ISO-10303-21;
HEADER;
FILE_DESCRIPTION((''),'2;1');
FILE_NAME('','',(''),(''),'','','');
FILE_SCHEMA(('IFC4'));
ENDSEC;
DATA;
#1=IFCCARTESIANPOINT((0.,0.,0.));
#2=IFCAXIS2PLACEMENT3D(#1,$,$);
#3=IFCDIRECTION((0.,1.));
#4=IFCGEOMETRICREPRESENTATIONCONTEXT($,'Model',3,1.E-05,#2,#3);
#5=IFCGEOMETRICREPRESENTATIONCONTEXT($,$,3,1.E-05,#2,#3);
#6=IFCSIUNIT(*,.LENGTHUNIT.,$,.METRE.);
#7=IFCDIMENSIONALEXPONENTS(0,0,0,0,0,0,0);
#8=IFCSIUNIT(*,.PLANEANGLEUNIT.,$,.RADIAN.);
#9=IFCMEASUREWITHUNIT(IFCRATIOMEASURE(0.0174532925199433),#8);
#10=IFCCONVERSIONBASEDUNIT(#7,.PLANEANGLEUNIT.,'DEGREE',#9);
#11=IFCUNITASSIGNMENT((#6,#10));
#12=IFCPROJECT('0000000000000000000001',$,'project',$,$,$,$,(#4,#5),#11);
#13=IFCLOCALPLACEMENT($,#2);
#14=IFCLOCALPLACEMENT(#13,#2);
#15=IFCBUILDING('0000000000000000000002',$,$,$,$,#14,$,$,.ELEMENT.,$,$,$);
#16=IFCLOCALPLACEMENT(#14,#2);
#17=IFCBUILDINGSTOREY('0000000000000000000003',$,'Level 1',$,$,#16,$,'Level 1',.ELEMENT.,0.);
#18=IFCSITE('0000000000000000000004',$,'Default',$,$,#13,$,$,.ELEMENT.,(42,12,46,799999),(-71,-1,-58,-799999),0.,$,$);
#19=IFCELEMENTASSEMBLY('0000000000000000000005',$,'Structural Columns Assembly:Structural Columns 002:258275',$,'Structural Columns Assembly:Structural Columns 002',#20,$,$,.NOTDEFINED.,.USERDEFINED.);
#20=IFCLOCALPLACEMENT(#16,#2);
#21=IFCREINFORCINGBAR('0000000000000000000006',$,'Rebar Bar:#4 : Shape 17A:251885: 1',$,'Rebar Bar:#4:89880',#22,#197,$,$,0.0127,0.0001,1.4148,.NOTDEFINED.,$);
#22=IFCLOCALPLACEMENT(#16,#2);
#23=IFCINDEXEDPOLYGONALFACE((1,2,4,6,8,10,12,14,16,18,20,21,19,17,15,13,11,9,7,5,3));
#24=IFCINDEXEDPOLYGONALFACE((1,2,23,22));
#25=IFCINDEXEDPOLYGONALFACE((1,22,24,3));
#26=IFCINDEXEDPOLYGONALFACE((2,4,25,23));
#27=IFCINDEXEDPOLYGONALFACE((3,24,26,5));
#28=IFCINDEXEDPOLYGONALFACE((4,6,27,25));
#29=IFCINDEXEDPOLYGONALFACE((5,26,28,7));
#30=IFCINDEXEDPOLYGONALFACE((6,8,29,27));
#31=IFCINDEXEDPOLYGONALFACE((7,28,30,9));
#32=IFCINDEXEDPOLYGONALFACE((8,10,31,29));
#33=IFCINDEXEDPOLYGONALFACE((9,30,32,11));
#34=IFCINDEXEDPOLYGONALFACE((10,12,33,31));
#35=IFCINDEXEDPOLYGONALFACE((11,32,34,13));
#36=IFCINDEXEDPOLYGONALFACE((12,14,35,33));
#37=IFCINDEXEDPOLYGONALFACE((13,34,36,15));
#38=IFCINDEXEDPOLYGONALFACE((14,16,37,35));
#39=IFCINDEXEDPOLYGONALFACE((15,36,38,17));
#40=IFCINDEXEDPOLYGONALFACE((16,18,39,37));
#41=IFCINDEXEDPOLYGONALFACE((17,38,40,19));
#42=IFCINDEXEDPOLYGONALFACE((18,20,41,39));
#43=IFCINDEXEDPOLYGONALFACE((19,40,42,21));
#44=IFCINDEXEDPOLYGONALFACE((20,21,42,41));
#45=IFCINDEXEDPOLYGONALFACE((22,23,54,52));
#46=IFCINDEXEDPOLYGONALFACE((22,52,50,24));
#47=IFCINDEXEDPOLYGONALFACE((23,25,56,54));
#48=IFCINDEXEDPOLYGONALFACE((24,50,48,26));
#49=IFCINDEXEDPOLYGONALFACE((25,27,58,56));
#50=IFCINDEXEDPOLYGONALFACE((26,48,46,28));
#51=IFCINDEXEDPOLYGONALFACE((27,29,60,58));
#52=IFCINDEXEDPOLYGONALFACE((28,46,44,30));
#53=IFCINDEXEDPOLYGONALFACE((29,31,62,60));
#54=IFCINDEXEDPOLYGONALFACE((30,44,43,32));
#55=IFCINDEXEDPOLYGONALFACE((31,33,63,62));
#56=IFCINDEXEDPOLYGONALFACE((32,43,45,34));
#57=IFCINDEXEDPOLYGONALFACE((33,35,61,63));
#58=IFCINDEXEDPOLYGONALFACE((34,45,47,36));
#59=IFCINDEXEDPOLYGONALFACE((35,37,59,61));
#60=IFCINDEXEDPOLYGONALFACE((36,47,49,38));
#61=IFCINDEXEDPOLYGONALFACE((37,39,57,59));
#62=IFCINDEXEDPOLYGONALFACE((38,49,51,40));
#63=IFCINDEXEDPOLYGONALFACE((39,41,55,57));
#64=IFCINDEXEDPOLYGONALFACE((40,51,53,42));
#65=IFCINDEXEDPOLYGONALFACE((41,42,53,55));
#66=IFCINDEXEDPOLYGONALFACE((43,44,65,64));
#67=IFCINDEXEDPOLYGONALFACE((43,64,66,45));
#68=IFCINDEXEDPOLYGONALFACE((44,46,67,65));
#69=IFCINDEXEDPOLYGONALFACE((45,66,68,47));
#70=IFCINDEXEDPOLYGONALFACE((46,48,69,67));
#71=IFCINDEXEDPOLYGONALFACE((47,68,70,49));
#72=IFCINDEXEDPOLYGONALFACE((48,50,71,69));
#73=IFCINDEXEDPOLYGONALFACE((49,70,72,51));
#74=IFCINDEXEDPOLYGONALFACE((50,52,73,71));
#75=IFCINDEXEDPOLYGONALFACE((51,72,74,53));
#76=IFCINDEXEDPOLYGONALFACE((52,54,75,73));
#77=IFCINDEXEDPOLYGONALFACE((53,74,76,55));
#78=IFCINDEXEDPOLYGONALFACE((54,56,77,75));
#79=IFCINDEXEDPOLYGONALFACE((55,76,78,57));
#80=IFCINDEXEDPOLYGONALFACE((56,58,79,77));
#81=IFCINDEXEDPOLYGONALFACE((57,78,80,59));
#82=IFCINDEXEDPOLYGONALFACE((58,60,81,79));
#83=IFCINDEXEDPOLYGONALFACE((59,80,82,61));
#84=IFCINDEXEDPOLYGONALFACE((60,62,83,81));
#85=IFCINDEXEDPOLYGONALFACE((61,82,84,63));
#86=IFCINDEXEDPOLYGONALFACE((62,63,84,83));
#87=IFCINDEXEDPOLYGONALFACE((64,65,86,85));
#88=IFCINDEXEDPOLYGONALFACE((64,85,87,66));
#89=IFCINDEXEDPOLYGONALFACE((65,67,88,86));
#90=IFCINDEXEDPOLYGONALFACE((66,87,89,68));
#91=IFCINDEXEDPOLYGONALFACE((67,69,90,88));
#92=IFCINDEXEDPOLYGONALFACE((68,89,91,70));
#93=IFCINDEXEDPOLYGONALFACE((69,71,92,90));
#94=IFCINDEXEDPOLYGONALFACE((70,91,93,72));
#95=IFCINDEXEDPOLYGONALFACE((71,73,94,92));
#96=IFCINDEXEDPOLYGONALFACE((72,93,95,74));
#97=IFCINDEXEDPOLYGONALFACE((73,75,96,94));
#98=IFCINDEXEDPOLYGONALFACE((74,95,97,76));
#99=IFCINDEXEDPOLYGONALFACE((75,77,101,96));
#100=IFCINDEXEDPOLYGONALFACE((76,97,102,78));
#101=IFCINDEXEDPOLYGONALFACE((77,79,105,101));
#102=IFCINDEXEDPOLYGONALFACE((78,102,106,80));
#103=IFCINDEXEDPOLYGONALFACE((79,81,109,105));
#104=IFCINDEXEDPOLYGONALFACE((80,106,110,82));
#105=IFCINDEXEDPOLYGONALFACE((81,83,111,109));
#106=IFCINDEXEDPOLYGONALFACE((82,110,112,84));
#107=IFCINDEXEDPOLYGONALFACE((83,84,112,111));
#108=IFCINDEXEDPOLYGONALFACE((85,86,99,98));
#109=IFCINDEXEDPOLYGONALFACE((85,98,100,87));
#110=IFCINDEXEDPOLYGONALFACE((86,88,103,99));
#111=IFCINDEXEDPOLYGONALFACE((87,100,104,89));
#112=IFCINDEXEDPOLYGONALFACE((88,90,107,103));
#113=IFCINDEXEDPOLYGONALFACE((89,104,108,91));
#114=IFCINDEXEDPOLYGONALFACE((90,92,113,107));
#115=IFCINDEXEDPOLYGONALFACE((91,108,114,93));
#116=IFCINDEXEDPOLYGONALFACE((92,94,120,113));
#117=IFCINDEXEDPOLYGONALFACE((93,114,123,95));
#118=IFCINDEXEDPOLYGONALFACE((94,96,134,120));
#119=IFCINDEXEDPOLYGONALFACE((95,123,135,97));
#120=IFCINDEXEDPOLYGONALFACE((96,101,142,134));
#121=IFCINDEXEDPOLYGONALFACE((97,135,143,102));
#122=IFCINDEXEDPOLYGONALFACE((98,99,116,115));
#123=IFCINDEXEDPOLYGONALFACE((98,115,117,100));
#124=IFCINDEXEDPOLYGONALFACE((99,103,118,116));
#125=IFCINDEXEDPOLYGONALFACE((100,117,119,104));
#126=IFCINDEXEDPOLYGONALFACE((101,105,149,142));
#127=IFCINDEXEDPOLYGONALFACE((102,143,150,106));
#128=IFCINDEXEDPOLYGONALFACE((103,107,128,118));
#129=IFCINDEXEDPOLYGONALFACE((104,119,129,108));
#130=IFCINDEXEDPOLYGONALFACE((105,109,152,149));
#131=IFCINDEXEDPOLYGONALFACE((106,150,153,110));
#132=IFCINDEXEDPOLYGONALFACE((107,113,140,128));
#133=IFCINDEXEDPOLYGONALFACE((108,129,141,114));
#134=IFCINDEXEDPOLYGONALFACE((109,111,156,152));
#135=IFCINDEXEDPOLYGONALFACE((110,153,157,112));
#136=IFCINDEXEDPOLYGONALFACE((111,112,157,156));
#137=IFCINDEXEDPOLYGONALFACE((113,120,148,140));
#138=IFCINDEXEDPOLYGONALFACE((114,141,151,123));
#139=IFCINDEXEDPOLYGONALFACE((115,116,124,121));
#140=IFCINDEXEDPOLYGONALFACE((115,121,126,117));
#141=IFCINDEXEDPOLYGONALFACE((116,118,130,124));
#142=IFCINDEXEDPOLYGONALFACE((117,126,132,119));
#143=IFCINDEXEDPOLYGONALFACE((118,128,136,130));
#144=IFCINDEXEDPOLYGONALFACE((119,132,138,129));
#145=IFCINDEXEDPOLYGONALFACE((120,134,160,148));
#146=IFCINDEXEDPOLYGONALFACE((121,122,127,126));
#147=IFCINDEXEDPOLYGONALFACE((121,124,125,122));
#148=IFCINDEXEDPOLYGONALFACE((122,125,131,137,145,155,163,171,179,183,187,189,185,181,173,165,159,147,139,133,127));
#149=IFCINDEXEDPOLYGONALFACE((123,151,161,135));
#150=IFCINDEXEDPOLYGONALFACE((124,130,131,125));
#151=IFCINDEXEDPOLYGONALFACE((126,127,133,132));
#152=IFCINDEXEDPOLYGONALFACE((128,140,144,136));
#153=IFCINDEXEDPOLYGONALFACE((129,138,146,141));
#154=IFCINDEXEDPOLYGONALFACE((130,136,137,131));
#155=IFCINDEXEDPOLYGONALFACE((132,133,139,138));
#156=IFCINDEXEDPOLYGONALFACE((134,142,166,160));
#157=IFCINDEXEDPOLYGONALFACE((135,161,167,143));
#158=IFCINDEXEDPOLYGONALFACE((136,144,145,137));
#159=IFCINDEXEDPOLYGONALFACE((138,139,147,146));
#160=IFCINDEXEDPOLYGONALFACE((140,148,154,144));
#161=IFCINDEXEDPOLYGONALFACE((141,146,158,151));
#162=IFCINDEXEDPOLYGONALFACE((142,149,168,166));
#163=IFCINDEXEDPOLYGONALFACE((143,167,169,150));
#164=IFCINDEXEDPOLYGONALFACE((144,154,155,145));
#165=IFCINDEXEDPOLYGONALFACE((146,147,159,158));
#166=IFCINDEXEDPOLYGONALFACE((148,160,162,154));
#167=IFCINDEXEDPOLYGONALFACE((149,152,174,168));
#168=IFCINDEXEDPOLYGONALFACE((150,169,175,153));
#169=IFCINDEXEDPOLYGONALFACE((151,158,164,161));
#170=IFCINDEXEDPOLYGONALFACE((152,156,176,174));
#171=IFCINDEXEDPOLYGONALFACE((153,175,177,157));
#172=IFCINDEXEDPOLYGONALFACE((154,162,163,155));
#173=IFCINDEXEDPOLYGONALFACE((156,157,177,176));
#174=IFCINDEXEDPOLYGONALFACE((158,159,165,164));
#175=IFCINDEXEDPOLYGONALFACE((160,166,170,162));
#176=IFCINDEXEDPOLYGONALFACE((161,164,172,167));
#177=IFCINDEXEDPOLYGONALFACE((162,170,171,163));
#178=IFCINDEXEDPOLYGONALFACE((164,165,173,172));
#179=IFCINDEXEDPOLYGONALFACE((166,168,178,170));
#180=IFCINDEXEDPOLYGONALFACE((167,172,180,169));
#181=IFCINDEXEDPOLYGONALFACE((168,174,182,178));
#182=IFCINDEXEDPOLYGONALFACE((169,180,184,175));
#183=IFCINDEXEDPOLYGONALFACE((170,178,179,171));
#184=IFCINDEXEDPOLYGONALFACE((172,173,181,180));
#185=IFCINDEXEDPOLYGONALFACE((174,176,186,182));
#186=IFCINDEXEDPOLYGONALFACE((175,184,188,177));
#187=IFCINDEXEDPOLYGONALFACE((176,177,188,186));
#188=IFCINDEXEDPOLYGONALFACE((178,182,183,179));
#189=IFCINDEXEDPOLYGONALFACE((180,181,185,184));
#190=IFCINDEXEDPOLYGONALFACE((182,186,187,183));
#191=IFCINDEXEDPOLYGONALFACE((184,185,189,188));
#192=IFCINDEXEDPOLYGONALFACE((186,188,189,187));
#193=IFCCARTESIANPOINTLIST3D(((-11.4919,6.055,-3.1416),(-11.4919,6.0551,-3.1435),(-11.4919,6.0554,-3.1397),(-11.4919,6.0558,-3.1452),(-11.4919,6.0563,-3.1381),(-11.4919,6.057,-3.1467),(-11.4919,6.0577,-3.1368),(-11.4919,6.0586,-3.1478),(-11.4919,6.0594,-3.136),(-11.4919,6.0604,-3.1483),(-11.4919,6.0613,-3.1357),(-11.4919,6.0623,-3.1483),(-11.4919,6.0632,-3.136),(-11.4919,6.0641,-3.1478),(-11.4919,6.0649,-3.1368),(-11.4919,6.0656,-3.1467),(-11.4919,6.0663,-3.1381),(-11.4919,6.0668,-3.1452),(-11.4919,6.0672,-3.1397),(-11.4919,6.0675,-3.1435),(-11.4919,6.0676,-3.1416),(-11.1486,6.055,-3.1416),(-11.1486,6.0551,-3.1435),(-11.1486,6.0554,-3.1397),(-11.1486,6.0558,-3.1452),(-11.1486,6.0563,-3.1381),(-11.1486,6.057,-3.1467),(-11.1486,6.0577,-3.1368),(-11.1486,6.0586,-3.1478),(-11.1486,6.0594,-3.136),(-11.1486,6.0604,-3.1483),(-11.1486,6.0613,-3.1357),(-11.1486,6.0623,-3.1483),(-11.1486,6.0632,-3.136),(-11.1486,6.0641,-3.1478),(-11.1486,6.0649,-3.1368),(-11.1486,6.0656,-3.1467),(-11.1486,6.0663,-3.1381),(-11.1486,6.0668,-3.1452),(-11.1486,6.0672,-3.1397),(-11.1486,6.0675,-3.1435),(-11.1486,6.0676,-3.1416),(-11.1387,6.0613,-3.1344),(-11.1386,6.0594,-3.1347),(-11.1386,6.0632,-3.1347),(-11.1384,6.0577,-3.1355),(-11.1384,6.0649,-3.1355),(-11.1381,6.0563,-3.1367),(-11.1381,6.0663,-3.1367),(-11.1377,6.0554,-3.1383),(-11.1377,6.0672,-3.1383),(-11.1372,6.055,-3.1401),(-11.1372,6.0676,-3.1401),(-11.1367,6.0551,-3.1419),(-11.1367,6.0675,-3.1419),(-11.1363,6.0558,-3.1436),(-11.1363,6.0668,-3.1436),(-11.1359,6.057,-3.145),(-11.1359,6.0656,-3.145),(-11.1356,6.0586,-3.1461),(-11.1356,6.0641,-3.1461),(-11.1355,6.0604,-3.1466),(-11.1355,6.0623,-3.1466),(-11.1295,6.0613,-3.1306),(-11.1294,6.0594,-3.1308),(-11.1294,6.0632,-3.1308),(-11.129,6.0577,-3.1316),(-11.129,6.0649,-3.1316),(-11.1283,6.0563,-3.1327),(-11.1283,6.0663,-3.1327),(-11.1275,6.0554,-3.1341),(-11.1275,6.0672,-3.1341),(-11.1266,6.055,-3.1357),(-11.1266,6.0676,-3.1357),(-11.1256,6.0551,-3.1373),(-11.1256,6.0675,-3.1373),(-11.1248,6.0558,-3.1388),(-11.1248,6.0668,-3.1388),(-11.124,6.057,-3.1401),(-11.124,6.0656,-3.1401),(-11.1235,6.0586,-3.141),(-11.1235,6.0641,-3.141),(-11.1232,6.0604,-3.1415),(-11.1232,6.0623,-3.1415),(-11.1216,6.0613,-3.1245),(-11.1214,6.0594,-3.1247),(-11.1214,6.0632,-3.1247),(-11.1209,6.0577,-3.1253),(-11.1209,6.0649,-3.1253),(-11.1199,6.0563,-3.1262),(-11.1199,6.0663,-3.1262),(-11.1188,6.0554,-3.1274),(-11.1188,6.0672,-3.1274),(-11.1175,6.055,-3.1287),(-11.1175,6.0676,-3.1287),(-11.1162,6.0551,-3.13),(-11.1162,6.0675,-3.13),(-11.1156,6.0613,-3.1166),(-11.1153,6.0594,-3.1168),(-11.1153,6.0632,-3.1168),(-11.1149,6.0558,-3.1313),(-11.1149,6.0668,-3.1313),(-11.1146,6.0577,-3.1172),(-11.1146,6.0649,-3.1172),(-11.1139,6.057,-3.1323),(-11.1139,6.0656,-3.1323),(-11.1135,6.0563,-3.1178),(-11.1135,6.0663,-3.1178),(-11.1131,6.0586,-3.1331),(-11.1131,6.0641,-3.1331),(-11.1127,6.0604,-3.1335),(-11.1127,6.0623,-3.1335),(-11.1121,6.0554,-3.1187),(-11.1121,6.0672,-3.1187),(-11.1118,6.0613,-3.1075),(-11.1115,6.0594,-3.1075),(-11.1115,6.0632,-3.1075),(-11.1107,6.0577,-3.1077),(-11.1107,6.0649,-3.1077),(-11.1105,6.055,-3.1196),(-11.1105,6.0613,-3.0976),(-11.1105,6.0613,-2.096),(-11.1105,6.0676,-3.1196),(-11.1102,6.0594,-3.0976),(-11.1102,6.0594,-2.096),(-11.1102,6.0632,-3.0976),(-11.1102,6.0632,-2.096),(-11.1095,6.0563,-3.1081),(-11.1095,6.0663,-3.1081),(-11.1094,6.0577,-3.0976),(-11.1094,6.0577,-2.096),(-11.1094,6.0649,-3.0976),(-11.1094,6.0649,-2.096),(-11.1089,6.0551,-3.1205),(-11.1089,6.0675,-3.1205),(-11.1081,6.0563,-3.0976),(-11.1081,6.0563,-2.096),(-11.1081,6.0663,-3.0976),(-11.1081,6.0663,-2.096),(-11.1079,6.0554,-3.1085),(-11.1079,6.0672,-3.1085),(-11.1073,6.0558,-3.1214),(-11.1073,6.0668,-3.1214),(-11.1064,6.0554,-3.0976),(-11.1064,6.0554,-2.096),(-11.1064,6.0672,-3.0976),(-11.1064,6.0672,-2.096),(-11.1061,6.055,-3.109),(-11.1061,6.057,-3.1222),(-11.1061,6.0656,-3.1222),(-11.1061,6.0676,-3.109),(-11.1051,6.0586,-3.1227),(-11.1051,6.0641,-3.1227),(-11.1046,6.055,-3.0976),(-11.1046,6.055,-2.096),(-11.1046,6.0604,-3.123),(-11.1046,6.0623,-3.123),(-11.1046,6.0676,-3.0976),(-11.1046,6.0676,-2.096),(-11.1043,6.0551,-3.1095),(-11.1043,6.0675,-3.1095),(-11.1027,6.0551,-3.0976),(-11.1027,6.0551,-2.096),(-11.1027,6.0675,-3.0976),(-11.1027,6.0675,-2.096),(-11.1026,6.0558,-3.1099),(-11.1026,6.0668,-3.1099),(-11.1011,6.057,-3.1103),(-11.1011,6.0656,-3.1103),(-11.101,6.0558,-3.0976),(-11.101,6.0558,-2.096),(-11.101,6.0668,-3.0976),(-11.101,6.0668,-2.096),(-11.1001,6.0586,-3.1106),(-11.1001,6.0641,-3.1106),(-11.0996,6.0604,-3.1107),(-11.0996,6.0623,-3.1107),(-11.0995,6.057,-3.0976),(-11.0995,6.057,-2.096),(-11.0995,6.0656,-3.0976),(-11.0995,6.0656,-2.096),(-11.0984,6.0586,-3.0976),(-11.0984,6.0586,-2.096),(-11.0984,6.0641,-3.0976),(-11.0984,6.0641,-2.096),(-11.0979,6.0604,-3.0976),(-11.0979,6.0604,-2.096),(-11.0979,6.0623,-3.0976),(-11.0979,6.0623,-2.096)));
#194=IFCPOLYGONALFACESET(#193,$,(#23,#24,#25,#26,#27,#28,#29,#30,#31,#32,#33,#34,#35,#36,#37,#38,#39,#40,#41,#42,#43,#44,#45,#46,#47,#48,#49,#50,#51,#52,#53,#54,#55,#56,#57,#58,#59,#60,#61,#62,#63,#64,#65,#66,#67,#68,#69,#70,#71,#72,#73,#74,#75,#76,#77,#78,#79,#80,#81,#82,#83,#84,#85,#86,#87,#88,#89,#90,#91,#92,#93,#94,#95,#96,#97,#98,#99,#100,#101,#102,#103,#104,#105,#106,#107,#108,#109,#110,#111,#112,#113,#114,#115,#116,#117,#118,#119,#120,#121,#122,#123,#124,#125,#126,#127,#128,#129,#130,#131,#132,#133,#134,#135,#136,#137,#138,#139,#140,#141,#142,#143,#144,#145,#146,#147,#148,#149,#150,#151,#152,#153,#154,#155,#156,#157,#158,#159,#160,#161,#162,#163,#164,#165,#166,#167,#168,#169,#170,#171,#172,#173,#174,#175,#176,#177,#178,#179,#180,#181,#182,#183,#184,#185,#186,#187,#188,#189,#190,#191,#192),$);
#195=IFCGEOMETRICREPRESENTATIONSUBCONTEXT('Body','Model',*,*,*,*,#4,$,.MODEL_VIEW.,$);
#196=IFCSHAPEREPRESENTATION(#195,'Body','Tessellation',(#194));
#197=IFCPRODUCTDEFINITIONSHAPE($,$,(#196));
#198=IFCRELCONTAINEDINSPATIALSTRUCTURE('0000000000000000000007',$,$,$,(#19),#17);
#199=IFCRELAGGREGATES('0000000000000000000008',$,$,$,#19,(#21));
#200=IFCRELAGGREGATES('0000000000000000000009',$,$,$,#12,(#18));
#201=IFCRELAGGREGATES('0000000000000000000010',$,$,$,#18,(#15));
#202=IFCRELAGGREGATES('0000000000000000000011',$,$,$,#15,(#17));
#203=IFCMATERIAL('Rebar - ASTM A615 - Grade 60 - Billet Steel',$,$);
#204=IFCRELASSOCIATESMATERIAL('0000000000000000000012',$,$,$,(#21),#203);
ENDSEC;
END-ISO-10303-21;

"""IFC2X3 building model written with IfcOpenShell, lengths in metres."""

from ifc_helpers import new_model, entity, si_unit, converted_unit, direction, origin, place, context, subcontext, project, spatial, material, element, aggregate, save


model = new_model("IFC2X3")

# Units and contexts
model_context = context("Model", 3, precision=1e-05, world=origin(), true_north=direction((0.0, 1.0)))
context_of_model = context(None, 3, precision=1e-05, world=origin(), true_north=direction((0.0, 1.0)))
body_context = subcontext(model_context, "Body", "Model", "MODEL_VIEW")
ifc_project = project(units=[si_unit("LENGTHUNIT", "METRE"), converted_unit("PLANEANGLEUNIT", "DEGREE", entity("IfcRatioMeasure", 0.0174532925199433), si_unit("PLANEANGLEUNIT", "RADIAN"), dimensions=[0, 0, 0, 0, 0, 0, 0])], contexts=[model_context, context_of_model])

# Site, building, storey
site_placement = place(None, origin())
site = spatial("IfcSite", under=ifc_project, at=site_placement, Name="Default", CompositionType="ELEMENT", RefLatitude=(42, 12, 46, 799999), RefLongitude=(-71, -1, -58, -799999), RefElevation=0.0)
building_placement = place(site_placement, origin())
building = spatial("IfcBuilding", under=site, at=building_placement, CompositionType="ELEMENT")
storey_placement = place(building_placement, origin())
storey = spatial("IfcBuildingStorey", under=building, at=storey_placement, Name="Level 1", LongName="Level 1", CompositionType="ELEMENT", Elevation=0.0)

# Element assembly, reinforcing bar
assembly_1_placement = place(storey_placement, origin())
assembly_1 = element("IfcElementAssembly", 1, at=assembly_1_placement, inside=storey, Name="Structural Columns Assembly:Structural Columns 002:258275", ObjectType="Structural Columns Assembly:Structural Columns 002", AssemblyPlace="NOTDEFINED", PredefinedType="USERDEFINED")
ifc_material_1 = material(Name="Rebar - ASTM A615 - Grade 60 - Billet Steel")
reinforcing_bar_1_placement = place(assembly_1_placement, origin())
reinforcing_bar_1 = element("IfcReinforcingBar", 2, at=reinforcing_bar_1_placement, material=ifc_material_1, Name="Rebar Bar:#4 : Shape 17A:251885: 1", ObjectType="Rebar Bar:#4:89880", BarLength=1.4148, BarRole="NOTDEFINED", CrossSectionArea=0.0001, NominalDiameter=0.0127, context=body_context, shape_type="AdvancedSweptSolid", body=[
    entity("IfcSweptDiskSolid", entity("IfcCompositeCurve", [entity("IfcCompositeCurveSegment", "CONTINUOUS", True, entity("IfcPolyline", [entity("IfcCartesianPoint", [-11.4919, 6.0613, -3.142]), entity("IfcCartesianPoint", [-11.1486, 6.0613, -3.142])])), entity("IfcCompositeCurveSegment", "CONTINUOUS", True, entity("IfcTrimmedCurve", entity("IfcCircle", entity("IfcAxis2Placement3D", entity("IfcCartesianPoint", [-11.1486, 6.0613, -3.0976]), entity("IfcDirection", [0.0, -1.0, 0.0]), entity("IfcDirection", [1.0, 0.0, 0.0])), 0.0445), [entity("IfcParameterValue", 270.0)], [entity("IfcParameterValue", 360.0)], True, "PARAMETER")), entity("IfcCompositeCurveSegment", "CONTINUOUS", True, entity("IfcPolyline", [entity("IfcCartesianPoint", [-11.1041, 6.0613, -3.0976]), entity("IfcCartesianPoint", [-11.1041, 6.0613, -2.096])]))], False), 0.0063, None, 0.0, 92.0),
])
aggregate(assembly_1, [reinforcing_bar_1])

save(model, "model.ifc")
